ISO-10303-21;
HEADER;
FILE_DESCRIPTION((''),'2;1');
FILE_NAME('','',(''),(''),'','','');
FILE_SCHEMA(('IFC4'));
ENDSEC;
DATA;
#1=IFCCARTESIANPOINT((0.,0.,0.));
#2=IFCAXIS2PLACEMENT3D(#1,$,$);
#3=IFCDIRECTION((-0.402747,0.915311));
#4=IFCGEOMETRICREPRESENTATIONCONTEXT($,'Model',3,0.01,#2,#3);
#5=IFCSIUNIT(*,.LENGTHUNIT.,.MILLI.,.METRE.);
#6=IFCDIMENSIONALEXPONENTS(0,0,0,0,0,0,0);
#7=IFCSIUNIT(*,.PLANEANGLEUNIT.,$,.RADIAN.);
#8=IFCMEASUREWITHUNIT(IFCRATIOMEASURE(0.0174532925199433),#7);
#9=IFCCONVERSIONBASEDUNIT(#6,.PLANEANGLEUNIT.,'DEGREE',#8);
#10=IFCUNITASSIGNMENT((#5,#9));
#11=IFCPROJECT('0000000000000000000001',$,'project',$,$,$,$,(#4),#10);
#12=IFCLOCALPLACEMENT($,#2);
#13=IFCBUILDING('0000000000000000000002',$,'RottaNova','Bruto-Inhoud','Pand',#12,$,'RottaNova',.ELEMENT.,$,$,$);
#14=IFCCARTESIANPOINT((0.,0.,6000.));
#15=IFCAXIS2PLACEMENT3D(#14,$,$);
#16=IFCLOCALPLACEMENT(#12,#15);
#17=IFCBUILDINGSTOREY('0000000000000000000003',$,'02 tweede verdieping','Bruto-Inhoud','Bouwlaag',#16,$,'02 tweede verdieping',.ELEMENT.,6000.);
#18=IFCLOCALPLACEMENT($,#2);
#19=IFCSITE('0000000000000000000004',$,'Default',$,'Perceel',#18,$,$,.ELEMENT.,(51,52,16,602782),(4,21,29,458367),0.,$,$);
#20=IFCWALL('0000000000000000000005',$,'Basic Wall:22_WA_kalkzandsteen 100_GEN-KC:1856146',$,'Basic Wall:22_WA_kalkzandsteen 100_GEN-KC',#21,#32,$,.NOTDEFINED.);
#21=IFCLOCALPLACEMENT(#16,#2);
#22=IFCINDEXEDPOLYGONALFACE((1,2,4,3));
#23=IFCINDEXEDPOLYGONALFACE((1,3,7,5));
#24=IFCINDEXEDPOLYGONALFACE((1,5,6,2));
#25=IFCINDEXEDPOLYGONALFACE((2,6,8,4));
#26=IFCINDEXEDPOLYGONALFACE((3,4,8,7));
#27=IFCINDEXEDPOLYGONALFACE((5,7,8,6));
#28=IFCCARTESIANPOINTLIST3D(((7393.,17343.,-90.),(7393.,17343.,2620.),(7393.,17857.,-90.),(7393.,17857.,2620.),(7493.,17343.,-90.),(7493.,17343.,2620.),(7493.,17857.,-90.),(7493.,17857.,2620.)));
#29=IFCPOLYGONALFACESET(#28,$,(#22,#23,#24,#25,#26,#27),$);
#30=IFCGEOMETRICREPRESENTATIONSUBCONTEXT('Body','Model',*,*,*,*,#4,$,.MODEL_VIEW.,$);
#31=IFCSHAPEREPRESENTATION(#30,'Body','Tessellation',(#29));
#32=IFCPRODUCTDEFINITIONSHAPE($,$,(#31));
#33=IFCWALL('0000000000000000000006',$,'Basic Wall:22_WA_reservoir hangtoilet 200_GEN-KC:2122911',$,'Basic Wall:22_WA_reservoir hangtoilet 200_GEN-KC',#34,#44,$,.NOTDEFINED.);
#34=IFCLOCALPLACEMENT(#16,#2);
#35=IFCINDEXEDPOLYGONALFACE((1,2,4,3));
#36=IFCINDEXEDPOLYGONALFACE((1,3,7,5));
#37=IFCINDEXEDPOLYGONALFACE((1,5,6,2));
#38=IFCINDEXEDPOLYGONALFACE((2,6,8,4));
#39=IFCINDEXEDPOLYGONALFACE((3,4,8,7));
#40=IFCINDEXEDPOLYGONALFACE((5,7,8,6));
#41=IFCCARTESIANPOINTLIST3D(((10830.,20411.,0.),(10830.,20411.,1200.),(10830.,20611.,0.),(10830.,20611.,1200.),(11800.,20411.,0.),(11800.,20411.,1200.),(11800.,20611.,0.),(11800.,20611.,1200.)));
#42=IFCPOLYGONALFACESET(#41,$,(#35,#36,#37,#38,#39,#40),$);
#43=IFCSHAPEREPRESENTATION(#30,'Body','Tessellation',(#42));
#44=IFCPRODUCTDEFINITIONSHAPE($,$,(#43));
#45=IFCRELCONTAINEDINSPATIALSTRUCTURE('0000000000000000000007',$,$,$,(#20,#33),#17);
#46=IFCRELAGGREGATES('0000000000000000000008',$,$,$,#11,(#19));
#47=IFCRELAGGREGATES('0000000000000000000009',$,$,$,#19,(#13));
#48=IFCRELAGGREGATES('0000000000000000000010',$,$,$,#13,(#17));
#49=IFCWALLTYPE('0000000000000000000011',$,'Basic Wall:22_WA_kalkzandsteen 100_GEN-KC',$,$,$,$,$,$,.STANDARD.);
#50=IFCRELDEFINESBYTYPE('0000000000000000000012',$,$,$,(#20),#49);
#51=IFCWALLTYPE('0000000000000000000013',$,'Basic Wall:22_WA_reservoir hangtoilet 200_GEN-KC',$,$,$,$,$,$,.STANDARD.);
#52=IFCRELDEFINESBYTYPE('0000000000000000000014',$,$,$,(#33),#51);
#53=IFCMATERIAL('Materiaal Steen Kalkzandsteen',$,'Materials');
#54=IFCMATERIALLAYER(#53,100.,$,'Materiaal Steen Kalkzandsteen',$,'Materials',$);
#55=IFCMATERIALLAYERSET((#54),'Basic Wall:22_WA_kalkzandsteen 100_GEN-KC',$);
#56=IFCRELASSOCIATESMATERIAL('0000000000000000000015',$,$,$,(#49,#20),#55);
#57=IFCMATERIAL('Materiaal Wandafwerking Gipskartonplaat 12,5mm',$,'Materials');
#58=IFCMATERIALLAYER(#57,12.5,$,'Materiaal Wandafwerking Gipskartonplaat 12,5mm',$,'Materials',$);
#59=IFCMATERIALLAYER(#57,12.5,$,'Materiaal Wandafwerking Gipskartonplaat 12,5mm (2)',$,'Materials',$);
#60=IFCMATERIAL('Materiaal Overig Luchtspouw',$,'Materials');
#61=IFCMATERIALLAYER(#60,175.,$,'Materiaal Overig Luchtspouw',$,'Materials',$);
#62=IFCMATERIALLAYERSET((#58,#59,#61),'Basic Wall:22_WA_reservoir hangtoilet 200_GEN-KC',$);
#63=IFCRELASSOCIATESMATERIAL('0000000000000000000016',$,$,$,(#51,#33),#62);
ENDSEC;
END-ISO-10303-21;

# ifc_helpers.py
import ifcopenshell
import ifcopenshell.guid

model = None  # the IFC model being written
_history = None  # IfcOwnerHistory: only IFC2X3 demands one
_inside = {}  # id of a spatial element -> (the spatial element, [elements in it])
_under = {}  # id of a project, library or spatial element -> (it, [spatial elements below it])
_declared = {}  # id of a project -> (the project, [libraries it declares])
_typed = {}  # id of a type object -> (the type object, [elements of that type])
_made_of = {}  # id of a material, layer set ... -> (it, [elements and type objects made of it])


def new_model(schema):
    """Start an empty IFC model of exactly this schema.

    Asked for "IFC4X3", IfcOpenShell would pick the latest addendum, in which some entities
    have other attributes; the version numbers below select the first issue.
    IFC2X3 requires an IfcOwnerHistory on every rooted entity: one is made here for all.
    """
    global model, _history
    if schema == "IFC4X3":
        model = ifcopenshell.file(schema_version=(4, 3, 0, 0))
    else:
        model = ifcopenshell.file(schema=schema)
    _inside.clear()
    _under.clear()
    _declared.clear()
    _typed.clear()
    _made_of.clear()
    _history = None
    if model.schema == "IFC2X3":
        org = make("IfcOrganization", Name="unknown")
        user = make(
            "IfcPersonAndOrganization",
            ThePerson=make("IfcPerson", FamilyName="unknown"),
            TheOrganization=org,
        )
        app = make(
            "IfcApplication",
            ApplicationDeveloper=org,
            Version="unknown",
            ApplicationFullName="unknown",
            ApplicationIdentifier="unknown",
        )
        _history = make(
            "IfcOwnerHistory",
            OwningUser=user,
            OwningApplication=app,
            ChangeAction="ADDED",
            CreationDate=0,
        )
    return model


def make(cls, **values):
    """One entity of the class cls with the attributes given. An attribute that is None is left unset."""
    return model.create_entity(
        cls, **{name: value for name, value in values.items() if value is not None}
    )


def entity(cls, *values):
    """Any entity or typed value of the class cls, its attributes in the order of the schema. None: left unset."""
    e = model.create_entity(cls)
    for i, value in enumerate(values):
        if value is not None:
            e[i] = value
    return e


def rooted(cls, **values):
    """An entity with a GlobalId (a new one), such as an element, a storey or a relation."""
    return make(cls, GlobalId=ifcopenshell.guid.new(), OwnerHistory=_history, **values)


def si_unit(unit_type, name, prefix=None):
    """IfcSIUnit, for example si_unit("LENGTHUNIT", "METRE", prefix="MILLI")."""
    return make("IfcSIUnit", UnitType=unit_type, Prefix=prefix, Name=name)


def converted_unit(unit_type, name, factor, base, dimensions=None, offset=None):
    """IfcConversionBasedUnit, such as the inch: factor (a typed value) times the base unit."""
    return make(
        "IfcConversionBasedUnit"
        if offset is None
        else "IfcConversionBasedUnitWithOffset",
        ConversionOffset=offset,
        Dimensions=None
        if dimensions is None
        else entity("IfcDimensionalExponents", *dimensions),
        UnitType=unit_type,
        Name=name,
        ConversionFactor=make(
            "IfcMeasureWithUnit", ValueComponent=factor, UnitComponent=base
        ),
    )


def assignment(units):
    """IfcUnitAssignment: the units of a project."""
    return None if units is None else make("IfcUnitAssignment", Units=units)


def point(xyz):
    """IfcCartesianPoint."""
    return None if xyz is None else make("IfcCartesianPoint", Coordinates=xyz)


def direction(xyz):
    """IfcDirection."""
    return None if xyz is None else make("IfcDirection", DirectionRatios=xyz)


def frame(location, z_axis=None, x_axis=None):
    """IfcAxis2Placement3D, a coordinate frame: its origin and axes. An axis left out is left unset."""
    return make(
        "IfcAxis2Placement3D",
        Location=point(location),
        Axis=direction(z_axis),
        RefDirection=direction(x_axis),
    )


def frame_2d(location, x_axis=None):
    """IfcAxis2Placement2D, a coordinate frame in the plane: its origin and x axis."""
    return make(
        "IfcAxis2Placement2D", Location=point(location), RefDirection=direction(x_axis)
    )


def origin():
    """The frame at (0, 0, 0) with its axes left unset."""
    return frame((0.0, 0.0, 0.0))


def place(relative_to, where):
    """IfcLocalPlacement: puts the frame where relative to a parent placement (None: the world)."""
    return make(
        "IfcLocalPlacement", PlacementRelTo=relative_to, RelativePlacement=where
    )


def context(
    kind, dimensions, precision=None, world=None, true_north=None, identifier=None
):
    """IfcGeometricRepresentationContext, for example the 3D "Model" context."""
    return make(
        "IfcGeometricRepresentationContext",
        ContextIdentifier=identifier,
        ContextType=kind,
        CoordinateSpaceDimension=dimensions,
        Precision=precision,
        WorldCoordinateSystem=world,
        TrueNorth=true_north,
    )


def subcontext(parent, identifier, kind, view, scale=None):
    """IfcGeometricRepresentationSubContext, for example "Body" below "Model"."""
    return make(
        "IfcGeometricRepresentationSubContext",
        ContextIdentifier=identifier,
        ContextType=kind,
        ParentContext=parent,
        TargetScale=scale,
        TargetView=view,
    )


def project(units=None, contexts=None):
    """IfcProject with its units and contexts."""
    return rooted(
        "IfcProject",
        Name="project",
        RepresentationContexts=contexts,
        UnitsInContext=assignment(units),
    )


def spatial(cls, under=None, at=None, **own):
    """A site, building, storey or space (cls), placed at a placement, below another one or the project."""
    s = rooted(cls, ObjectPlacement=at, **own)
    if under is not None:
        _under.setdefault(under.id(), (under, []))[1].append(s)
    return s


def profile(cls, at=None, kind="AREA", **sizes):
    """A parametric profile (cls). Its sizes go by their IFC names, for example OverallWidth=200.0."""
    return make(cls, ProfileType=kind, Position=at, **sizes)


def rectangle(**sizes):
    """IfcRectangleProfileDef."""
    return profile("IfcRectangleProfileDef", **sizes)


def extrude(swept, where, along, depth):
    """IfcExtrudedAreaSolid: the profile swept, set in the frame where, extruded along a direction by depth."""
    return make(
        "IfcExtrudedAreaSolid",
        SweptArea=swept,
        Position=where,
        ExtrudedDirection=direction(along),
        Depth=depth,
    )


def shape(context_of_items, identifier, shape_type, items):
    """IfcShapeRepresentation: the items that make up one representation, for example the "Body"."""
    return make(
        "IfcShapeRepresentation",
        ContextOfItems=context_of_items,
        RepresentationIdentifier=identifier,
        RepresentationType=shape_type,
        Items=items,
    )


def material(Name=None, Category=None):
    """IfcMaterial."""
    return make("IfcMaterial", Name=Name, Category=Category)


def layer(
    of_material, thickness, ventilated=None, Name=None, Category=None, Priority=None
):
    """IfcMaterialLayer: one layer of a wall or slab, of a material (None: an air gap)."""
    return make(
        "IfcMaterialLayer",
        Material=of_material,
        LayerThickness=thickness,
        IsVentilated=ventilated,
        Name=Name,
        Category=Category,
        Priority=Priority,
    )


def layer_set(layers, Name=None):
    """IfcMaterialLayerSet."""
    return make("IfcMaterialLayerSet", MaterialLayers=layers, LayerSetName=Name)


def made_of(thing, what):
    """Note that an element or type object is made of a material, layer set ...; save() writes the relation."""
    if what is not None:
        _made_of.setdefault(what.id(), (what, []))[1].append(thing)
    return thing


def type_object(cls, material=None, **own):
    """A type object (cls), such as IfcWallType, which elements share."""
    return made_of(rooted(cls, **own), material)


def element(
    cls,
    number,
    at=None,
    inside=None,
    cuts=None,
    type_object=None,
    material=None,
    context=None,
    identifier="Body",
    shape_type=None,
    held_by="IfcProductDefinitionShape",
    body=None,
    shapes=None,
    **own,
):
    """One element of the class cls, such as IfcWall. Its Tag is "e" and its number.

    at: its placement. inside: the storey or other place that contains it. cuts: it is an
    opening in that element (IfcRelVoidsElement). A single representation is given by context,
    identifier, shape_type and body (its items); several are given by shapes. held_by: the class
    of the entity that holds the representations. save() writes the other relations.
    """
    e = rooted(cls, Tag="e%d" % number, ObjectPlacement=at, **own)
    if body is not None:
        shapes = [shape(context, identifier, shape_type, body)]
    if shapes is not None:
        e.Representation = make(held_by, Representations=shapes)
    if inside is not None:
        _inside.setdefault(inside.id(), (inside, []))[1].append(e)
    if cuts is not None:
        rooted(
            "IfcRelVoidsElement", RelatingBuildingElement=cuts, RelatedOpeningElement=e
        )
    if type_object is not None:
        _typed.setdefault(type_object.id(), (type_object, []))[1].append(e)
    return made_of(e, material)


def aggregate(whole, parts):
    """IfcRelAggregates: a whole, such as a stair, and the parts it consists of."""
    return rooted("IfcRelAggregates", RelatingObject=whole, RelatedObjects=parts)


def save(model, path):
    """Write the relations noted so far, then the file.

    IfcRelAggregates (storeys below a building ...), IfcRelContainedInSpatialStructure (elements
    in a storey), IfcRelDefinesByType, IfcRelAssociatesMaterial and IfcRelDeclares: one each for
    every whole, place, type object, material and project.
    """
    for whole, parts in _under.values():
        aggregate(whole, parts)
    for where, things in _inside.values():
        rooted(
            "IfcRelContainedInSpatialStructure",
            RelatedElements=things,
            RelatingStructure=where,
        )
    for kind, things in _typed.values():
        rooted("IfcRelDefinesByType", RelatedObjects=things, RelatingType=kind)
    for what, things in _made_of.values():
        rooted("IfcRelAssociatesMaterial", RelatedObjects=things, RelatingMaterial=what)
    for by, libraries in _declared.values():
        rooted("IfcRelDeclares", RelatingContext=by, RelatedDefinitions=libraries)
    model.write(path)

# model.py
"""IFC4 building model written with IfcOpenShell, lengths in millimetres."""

from ifc_helpers import new_model, entity, si_unit, converted_unit, direction, frame, frame_2d, origin, place, context, subcontext, project, spatial, rectangle, extrude, material, layer, layer_set, type_object, element, save


model = new_model("IFC4")

# Units and contexts
model_context = context("Model", 3, precision=0.01, world=origin(), true_north=direction((-0.402747, 0.915311)))
body_context = subcontext(model_context, "Body", "Model", "MODEL_VIEW")
ifc_project = project(units=[si_unit("LENGTHUNIT", "METRE", prefix="MILLI"), converted_unit("PLANEANGLEUNIT", "DEGREE", entity("IfcRatioMeasure", 0.0174532925199433), si_unit("PLANEANGLEUNIT", "RADIAN"), dimensions=[0, 0, 0, 0, 0, 0, 0])], contexts=[model_context])

# Site, building, storey
site_placement = place(None, origin())
site = spatial("IfcSite", under=ifc_project, at=site_placement, Name="Default", ObjectType="Perceel", CompositionType="ELEMENT", RefLatitude=(51, 52, 16, 602782), RefLongitude=(4, 21, 29, 458367), RefElevation=0.0)
building_placement = place(None, origin())
building = spatial("IfcBuilding", under=site, at=building_placement, Name="RottaNova", Description="Bruto-Inhoud", ObjectType="Pand", LongName="RottaNova", CompositionType="ELEMENT")
storey_placement = place(building_placement, frame((0.0, 0.0, 6000.0)))
storey = spatial("IfcBuildingStorey", under=building, at=storey_placement, Name="02 tweede verdieping", Description="Bruto-Inhoud", ObjectType="Bouwlaag", LongName="02 tweede verdieping", CompositionType="ELEMENT", Elevation=6000.0)

# Shared definitions
ifc_material_1 = material(Name="Materiaal Steen Kalkzandsteen", Category="Materials")

# Walls
ifc_layer_1 = layer(ifc_material_1, 100.0, Name="Materiaal Steen Kalkzandsteen", Category="Materials")
ifc_layer_set_1 = layer_set([ifc_layer_1], Name="Basic Wall:22_WA_kalkzandsteen 100_GEN-KC")
wall_type_1 = type_object("IfcWallType", Name="Basic Wall:22_WA_kalkzandsteen 100_GEN-KC", PredefinedType="STANDARD", material=ifc_layer_set_1)
wall_1_placement = place(storey_placement, frame((7443.0, 17343.0, -90.0), z_axis=(0.0, 0.0, 1.0), x_axis=(0.0, 1.0, 0.0)))
element("IfcWall", 1, at=wall_1_placement, inside=storey, type_object=wall_type_1, material=ifc_layer_set_1, Name="Basic Wall:22_WA_kalkzandsteen 100_GEN-KC:1856146", ObjectType="Basic Wall:22_WA_kalkzandsteen 100_GEN-KC", PredefinedType="NOTDEFINED", context=body_context, shape_type="SweptSolid", body=[
    extrude(rectangle(XDim=514.0, YDim=100.0, at=frame_2d((257.0, 0.0), x_axis=(-1.0, 0.0))), origin(), (0.0, 0.0, 1.0), 2710.0),
])
ifc_material_2 = material(Name="Materiaal Wandafwerking Gipskartonplaat 12,5mm", Category="Materials")
ifc_layer_2 = layer(ifc_material_2, 12.5, Name="Materiaal Wandafwerking Gipskartonplaat 12,5mm", Category="Materials")
ifc_layer_3 = layer(ifc_material_2, 12.5, Name="Materiaal Wandafwerking Gipskartonplaat 12,5mm (2)", Category="Materials")
ifc_material_3 = material(Name="Materiaal Overig Luchtspouw", Category="Materials")
ifc_layer_4 = layer(ifc_material_3, 175.0, Name="Materiaal Overig Luchtspouw", Category="Materials")
ifc_layer_set_2 = layer_set([ifc_layer_2, ifc_layer_3, ifc_layer_4], Name="Basic Wall:22_WA_reservoir hangtoilet 200_GEN-KC")
wall_type_2 = type_object("IfcWallType", Name="Basic Wall:22_WA_reservoir hangtoilet 200_GEN-KC", PredefinedType="STANDARD", material=ifc_layer_set_2)
wall_2_placement = place(storey_placement, frame((10830.0, 20511.0, 0.0)))
element("IfcWall", 2, at=wall_2_placement, inside=storey, type_object=wall_type_2, material=ifc_layer_set_2, Name="Basic Wall:22_WA_reservoir hangtoilet 200_GEN-KC:2122911", ObjectType="Basic Wall:22_WA_reservoir hangtoilet 200_GEN-KC", PredefinedType="NOTDEFINED", context=body_context, shape_type="SweptSolid", body=[
    extrude(rectangle(XDim=970.0, YDim=200.0, at=frame_2d((485.0, 0.0), x_axis=(-1.0, 0.0))), origin(), (0.0, 0.0, 1.0), 1200.0),
])

save(model, "model.ifc")
